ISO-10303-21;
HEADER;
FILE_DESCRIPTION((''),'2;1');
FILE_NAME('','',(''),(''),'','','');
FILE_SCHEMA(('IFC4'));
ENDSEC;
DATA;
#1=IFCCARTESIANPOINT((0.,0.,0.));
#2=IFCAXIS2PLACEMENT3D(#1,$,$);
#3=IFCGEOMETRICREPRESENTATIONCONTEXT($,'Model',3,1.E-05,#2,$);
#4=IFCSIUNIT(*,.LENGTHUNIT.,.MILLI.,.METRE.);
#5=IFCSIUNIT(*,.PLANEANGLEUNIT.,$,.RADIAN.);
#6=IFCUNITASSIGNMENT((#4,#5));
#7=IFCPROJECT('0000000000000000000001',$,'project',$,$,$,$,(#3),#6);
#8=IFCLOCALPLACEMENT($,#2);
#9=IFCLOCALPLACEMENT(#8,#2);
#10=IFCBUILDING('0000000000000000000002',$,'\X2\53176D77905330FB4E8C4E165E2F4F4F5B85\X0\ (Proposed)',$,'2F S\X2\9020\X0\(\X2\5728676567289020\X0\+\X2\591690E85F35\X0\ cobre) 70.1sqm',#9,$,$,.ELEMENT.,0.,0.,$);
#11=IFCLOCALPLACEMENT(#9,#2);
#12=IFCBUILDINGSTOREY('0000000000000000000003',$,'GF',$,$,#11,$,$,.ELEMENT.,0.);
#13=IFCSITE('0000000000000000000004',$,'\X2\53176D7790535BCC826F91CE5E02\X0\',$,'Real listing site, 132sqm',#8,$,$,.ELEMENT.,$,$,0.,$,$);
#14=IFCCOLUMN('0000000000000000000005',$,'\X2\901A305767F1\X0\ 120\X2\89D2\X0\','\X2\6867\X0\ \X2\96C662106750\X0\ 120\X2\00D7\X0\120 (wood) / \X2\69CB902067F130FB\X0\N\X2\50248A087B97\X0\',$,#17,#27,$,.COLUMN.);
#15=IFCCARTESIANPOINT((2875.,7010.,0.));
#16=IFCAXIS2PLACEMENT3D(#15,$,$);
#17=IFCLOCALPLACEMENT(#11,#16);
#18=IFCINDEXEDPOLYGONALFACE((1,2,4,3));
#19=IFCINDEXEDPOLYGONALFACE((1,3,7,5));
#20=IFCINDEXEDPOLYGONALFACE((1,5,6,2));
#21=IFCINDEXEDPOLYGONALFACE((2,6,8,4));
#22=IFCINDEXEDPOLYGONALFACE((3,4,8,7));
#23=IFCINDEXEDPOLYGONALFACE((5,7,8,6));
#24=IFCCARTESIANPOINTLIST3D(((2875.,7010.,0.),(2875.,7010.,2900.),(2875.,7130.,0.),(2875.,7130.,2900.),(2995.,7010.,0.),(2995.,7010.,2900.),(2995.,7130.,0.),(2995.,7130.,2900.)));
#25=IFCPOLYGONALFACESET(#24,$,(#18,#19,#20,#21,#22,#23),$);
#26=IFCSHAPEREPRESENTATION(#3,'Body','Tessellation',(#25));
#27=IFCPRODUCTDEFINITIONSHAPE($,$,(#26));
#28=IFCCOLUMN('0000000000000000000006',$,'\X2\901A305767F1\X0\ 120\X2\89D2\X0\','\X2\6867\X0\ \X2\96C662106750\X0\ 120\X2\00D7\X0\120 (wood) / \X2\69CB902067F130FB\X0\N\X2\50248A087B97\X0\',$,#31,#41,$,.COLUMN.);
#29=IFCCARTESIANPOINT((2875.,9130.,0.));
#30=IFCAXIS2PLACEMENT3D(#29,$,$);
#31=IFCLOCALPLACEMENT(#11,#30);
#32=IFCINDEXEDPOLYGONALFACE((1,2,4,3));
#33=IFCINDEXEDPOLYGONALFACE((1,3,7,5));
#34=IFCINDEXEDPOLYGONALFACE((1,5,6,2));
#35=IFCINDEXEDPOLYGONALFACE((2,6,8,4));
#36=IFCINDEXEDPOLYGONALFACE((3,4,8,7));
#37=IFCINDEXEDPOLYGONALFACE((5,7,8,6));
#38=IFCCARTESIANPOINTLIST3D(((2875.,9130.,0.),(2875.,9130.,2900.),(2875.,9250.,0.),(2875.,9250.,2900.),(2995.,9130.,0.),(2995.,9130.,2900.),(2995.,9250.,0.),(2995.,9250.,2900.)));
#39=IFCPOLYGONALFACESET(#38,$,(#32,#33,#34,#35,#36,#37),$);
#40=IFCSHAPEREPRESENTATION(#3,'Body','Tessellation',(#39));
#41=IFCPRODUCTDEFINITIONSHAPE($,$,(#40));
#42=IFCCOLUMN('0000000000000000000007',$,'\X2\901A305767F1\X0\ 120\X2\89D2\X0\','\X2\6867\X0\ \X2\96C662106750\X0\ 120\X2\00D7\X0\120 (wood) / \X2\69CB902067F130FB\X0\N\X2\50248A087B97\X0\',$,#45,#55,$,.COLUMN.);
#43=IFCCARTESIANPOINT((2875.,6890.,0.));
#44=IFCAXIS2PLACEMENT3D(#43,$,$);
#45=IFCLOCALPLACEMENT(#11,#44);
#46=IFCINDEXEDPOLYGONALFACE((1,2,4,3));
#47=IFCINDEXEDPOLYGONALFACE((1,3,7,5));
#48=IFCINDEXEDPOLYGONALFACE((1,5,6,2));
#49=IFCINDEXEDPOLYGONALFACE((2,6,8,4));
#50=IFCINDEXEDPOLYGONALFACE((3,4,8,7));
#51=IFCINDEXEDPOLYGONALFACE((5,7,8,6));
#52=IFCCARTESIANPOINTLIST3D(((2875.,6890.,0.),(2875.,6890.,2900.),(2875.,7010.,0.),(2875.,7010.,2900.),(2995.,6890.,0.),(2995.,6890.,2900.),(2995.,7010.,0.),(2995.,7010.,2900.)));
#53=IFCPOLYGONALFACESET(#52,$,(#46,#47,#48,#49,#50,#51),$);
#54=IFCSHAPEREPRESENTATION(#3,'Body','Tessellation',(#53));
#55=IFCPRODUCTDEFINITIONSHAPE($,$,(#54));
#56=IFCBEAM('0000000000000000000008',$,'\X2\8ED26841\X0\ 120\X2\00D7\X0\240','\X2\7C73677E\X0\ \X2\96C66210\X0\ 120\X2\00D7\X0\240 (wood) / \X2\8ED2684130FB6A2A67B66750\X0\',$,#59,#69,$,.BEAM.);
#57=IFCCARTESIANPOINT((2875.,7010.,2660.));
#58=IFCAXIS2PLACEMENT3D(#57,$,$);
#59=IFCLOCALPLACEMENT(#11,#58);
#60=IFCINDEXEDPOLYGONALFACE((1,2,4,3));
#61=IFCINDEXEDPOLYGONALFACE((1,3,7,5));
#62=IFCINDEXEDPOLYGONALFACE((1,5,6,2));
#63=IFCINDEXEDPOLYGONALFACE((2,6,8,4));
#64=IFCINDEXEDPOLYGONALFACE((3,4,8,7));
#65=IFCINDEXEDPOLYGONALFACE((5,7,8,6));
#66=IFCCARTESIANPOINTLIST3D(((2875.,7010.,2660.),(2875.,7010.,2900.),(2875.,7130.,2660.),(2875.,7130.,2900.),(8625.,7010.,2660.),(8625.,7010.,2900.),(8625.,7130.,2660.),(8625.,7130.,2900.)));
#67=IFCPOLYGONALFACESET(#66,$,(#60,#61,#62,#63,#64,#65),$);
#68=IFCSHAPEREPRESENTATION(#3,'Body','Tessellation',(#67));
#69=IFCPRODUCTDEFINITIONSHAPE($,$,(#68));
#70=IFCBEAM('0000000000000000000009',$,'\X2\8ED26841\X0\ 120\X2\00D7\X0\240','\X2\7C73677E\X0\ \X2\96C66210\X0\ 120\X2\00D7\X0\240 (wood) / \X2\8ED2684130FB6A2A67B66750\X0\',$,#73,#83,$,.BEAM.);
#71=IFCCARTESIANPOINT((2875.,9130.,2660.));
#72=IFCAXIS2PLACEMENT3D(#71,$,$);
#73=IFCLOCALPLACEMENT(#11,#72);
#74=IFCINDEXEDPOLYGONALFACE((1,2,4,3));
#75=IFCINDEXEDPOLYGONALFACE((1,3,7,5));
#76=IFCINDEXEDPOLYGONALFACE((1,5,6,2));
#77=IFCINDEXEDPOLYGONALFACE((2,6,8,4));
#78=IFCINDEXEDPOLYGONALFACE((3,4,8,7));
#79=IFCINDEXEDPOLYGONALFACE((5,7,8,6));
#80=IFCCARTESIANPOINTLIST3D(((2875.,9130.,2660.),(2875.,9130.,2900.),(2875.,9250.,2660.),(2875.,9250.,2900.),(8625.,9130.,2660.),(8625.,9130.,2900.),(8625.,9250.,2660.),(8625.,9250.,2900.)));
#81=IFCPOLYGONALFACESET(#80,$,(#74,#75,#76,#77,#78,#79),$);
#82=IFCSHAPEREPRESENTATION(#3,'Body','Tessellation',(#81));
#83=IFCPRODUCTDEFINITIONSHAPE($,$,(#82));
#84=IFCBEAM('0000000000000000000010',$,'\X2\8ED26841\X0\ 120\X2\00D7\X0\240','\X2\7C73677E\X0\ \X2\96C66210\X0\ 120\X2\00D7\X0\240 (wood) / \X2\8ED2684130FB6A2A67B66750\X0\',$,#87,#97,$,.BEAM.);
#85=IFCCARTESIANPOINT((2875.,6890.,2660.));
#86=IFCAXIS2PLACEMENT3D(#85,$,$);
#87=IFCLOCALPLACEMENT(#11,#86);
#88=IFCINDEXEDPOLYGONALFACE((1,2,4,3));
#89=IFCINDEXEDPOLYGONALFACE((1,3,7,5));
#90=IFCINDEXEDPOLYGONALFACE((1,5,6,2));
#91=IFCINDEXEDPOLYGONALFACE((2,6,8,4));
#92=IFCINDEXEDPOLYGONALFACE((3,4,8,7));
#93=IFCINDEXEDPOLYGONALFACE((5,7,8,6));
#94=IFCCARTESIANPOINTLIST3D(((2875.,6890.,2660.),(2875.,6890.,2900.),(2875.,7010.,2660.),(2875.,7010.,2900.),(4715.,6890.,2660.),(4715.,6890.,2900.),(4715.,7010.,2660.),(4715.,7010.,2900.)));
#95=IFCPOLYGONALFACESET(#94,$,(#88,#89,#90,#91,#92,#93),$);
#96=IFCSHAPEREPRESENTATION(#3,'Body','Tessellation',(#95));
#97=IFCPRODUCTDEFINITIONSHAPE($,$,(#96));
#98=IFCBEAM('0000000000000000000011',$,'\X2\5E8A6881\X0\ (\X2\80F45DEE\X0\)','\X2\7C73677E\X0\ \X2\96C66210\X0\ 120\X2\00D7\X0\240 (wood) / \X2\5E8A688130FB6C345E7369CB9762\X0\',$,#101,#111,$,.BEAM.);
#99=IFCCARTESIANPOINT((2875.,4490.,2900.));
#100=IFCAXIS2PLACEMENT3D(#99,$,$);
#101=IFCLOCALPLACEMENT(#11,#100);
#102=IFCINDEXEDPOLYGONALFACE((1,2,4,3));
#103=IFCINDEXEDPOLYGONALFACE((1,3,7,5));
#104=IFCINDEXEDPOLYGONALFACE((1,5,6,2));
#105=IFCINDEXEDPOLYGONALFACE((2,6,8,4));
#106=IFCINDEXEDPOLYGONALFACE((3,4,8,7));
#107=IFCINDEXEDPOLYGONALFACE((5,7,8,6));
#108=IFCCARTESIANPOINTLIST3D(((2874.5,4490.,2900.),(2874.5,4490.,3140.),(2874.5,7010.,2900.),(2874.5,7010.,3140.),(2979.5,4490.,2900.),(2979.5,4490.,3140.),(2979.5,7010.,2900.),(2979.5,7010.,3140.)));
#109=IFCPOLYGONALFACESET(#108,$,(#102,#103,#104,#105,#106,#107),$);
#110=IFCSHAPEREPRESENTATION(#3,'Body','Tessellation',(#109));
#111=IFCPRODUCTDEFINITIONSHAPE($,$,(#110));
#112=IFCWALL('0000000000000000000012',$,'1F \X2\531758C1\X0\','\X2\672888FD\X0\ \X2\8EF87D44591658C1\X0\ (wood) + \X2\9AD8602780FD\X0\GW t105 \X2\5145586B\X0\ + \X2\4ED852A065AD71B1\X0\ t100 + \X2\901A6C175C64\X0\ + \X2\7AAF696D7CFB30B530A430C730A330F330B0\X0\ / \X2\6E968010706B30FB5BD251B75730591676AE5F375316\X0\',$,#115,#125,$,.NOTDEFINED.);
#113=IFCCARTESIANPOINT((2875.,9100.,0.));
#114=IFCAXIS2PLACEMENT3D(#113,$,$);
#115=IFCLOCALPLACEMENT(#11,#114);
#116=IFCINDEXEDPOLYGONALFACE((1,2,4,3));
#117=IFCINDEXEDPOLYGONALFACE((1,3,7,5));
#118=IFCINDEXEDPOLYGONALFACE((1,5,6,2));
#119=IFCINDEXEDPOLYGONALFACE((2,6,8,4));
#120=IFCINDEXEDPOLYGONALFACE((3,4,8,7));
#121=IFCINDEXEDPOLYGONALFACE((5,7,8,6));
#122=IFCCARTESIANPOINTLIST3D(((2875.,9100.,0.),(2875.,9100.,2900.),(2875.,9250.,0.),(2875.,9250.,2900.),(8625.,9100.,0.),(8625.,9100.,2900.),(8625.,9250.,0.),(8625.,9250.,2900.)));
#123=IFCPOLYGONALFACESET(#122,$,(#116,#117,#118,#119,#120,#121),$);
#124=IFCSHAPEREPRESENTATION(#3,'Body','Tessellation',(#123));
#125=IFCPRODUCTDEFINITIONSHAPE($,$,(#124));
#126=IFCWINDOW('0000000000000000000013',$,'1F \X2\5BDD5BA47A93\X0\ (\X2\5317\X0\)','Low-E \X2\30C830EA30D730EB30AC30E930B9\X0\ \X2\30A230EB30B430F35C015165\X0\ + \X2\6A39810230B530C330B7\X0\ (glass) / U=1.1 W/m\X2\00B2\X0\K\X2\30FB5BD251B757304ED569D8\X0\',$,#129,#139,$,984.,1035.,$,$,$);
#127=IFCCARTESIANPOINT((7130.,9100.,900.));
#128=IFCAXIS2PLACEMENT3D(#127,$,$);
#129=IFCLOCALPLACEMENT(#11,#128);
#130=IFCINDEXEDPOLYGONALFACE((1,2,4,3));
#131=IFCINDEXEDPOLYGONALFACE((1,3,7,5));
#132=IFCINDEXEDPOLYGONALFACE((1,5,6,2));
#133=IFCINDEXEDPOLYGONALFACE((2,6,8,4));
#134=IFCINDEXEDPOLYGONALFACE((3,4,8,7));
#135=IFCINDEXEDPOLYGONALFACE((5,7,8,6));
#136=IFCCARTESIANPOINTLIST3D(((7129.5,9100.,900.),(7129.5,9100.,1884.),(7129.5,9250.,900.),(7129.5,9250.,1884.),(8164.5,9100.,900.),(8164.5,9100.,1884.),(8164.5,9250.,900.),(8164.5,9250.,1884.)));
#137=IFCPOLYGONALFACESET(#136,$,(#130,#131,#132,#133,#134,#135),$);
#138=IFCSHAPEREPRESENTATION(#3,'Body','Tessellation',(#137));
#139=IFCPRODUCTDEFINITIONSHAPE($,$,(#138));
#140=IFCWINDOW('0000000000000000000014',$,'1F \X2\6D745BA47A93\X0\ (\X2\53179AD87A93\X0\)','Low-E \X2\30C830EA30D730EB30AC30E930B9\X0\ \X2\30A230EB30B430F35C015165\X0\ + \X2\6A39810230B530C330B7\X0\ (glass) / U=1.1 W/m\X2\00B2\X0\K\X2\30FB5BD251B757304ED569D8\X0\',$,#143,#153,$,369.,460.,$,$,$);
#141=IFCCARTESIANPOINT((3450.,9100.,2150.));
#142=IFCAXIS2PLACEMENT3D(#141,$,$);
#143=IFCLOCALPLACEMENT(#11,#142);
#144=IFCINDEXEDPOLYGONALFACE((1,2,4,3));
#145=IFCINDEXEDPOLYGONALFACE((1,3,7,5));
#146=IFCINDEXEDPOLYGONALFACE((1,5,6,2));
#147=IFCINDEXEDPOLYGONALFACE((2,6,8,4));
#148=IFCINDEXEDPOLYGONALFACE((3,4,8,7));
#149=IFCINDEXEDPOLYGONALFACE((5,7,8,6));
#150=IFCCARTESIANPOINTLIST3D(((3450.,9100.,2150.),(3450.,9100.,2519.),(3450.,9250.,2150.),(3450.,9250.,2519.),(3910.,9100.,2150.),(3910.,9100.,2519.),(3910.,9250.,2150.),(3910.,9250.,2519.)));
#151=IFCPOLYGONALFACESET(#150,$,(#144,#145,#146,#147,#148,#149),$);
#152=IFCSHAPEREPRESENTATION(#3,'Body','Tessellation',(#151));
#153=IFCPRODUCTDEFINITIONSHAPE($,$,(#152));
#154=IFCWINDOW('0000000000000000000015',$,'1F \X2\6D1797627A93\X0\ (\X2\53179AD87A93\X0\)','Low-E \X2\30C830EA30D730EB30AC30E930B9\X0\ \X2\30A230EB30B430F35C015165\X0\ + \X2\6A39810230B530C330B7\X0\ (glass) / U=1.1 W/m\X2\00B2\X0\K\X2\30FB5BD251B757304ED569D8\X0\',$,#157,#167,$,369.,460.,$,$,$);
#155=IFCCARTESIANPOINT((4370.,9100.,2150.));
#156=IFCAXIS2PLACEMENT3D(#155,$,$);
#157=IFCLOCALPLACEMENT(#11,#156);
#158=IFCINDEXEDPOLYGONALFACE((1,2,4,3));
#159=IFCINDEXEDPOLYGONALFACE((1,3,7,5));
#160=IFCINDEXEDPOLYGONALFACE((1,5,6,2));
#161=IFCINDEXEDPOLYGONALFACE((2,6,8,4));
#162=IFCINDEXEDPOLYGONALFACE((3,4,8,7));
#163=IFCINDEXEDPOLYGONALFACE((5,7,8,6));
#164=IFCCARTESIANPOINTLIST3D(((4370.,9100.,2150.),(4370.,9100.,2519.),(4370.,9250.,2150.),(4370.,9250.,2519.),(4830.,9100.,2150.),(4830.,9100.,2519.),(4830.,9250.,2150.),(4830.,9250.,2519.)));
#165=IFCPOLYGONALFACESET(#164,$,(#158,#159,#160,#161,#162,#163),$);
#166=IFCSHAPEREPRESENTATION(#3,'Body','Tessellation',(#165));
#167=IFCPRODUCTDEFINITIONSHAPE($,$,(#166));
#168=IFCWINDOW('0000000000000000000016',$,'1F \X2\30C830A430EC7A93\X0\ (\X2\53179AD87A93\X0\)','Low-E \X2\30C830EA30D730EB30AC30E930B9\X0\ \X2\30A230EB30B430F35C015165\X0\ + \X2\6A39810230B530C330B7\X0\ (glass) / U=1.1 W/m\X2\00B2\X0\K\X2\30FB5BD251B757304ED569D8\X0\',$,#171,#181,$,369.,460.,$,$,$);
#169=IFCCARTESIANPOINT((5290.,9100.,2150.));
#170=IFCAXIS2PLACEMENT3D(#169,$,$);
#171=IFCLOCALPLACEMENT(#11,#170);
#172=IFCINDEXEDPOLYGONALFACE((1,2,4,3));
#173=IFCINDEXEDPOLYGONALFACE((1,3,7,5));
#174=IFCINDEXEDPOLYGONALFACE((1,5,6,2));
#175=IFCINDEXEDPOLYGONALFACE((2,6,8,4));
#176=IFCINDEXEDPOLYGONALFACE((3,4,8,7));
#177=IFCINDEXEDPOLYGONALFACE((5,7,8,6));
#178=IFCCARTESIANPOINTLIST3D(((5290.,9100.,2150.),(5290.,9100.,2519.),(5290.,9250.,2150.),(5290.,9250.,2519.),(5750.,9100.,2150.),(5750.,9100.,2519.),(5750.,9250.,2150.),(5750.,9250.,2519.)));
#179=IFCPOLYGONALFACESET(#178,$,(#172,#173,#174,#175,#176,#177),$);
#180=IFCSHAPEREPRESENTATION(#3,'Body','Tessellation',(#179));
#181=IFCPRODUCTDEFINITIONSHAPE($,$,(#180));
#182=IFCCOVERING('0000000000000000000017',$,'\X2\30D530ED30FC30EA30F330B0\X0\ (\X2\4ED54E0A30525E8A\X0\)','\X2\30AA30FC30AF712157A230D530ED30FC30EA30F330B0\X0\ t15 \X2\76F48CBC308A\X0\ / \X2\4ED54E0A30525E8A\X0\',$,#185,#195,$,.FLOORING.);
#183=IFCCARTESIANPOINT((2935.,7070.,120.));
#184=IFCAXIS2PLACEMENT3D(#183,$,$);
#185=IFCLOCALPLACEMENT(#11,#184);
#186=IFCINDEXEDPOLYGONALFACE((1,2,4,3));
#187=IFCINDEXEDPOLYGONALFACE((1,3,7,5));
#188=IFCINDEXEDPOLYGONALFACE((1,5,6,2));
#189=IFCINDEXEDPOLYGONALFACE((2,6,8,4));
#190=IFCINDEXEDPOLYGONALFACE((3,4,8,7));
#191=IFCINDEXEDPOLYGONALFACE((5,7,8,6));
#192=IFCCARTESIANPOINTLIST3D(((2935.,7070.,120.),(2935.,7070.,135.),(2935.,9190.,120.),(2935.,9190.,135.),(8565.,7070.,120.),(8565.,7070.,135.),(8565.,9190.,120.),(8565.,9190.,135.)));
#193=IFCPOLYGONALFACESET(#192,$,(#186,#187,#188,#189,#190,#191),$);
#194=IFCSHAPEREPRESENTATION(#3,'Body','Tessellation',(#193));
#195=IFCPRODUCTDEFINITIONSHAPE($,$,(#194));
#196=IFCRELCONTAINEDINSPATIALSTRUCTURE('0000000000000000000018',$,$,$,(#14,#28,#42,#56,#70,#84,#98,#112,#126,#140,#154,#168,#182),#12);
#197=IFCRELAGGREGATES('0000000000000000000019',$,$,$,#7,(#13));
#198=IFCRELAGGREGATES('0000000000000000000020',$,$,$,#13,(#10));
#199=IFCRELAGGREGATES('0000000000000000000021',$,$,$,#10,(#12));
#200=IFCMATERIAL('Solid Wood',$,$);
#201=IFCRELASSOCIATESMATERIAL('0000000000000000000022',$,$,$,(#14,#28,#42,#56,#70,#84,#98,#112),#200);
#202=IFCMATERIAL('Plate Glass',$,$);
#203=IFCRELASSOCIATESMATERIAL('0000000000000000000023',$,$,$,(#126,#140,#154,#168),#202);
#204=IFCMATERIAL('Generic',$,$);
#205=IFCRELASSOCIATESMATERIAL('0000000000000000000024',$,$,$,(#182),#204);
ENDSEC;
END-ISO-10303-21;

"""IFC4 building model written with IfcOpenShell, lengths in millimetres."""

from ifc_helpers import new_model, si_unit, frame, frame_2d, origin, place, context, project, spatial, rectangle, extrude, material, element, fill, save


model = new_model("IFC4")

# Units and contexts
model_context = context("Model", 3, precision=1e-05, world=origin())
ifc_project = project(units=[si_unit("LENGTHUNIT", "METRE", prefix="MILLI"), si_unit("PLANEANGLEUNIT", "RADIAN")], contexts=[model_context])

# Site, building, storey
site_placement = place(None, origin())
site = spatial("IfcSite", under=ifc_project, at=site_placement, Name="北海道富良野市", ObjectType="Real listing site, 132sqm", CompositionType="ELEMENT", RefElevation=0.0)
building_placement = place(site_placement, origin())
building = spatial("IfcBuilding", under=site, at=building_placement, Name="北海道・二世帯住宅 (Proposed)", ObjectType="2F S造(在来木造+外部張 cobre) 70.1sqm", CompositionType="ELEMENT", ElevationOfRefHeight=0.0, ElevationOfTerrain=0.0)
storey_placement = place(building_placement, origin())
storey = spatial("IfcBuildingStorey", under=building, at=storey_placement, Name="GF", CompositionType="ELEMENT", Elevation=0.0)

# Columns
ifc_material_1 = material(Name="Solid Wood")
column_1_placement = place(storey_placement, frame((2875.0, 7010.0, 0.0)))
element("IfcColumn", 1, at=column_1_placement, inside=storey, material=ifc_material_1, Name="通し柱 120角", Description="桧 集成材 120×120 (wood) / 構造柱・N値計算", PredefinedType="COLUMN", context=model_context, shape_type="SweptSolid", body=[
    extrude(rectangle(XDim=120.0, YDim=120.0, at=frame_2d((60.0, 60.0))), frame((2875.0, 7010.0, 0.0)), (0.0, 0.0, 1.0), 2900.0),
])
column_2_placement = place(storey_placement, frame((2875.0, 9130.0, 0.0)))
element("IfcColumn", 2, at=column_2_placement, inside=storey, material=ifc_material_1, Name="通し柱 120角", Description="桧 集成材 120×120 (wood) / 構造柱・N値計算", PredefinedType="COLUMN", context=model_context, shape_type="SweptSolid", body=[
    extrude(rectangle(XDim=120.0, YDim=120.0, at=frame_2d((60.0, 60.0))), frame((2875.0, 9130.0, 0.0)), (0.0, 0.0, 1.0), 2900.0),
])
column_3_placement = place(storey_placement, frame((2875.0, 6890.0, 0.0)))
element("IfcColumn", 3, at=column_3_placement, inside=storey, material=ifc_material_1, Name="通し柱 120角", Description="桧 集成材 120×120 (wood) / 構造柱・N値計算", PredefinedType="COLUMN", context=model_context, shape_type="SweptSolid", body=[
    extrude(rectangle(XDim=120.0, YDim=120.0, at=frame_2d((60.0, 60.0))), frame((2875.0, 6890.0, 0.0)), (0.0, 0.0, 1.0), 2900.0),
])

# Beams
beam_1_placement = place(storey_placement, frame((2875.0, 7010.0, 2660.0)))
element("IfcBeam", 4, at=beam_1_placement, inside=storey, material=ifc_material_1, Name="軒桁 120×240", Description="米松 集成 120×240 (wood) / 軒桁・横架材", PredefinedType="BEAM", context=model_context, shape_type="SweptSolid", body=[
    extrude(rectangle(XDim=5750.0, YDim=120.0, at=frame_2d((2875.0, 60.0))), frame((2875.0, 7010.0, 2660.0)), (0.0, 0.0, 1.0), 240.0),
])
beam_2_placement = place(storey_placement, frame((2875.0, 9130.0, 2660.0)))
element("IfcBeam", 5, at=beam_2_placement, inside=storey, material=ifc_material_1, Name="軒桁 120×240", Description="米松 集成 120×240 (wood) / 軒桁・横架材", PredefinedType="BEAM", context=model_context, shape_type="SweptSolid", body=[
    extrude(rectangle(XDim=5750.0, YDim=120.0, at=frame_2d((2875.0, 60.0))), frame((2875.0, 9130.0, 2660.0)), (0.0, 0.0, 1.0), 240.0),
])
beam_3_placement = place(storey_placement, frame((2875.0, 6890.0, 2660.0)))
element("IfcBeam", 6, at=beam_3_placement, inside=storey, material=ifc_material_1, Name="軒桁 120×240", Description="米松 集成 120×240 (wood) / 軒桁・横架材", PredefinedType="BEAM", context=model_context, shape_type="SweptSolid", body=[
    extrude(rectangle(XDim=1840.0, YDim=120.0, at=frame_2d((920.0, 60.0))), frame((2875.0, 6890.0, 2660.0)), (0.0, 0.0, 1.0), 240.0),
])
beam_4_placement = place(storey_placement, frame((2875.0, 4490.0, 2900.0)))
element("IfcBeam", 7, at=beam_4_placement, inside=storey, material=ifc_material_1, Name="床梁 (胴差)", Description="米松 集成 120×240 (wood) / 床梁・水平構面", PredefinedType="BEAM", context=model_context, shape_type="SweptSolid", body=[
    extrude(rectangle(XDim=105.0, YDim=2520.0, at=frame_2d((52.0, 1260.0))), frame((2875.0, 4490.0, 2900.0)), (0.0, 0.0, 1.0), 240.0),
])

# Wall, openings, windows
wall_1_placement = place(storey_placement, frame((2875.0, 9100.0, 0.0)))
wall_1 = element("IfcWall", 8, at=wall_1_placement, inside=storey, material=ifc_material_1, Name="1F 北壁", Description="木製 軸組外壁 (wood) + 高性能GW t105 充填 + 付加断熱 t100 + 通気層 + 窯業系サイディング / 準耐火・寒冷地外皮強化", PredefinedType="NOTDEFINED", context=model_context, shape_type="SweptSolid", body=[
    extrude(rectangle(XDim=5750.0, YDim=150.0, at=frame_2d((2875.0, 75.0))), frame((2875.0, 9100.0, 0.0)), (0.0, 0.0, 1.0), 2900.0),
])
opening_1_placement = place(storey_placement, frame((7130.0, 9100.0, 900.0)))
opening_1 = element("IfcOpeningElement", 9, at=opening_1_placement, cuts=wall_1, PredefinedType="NOTDEFINED", context=model_context, shape_type="SweptSolid", body=[
    extrude(rectangle(XDim=1035.0, YDim=150.0, at=frame_2d((517.0, 75.0))), frame((7130.0, 9100.0, 900.0)), (0.0, 0.0, 1.0), 984.0),
])
opening_2_placement = place(storey_placement, frame((3450.0, 9100.0, 2150.0)))
opening_2 = element("IfcOpeningElement", 10, at=opening_2_placement, cuts=wall_1, PredefinedType="NOTDEFINED", context=model_context, shape_type="SweptSolid", body=[
    extrude(rectangle(XDim=460.0, YDim=150.0, at=frame_2d((230.0, 75.0))), frame((3450.0, 9100.0, 2150.0)), (0.0, 0.0, 1.0), 369.0),
])
opening_3_placement = place(storey_placement, frame((4370.0, 9100.0, 2150.0)))
opening_3 = element("IfcOpeningElement", 11, at=opening_3_placement, cuts=wall_1, PredefinedType="NOTDEFINED", context=model_context, shape_type="SweptSolid", body=[
    extrude(rectangle(XDim=460.0, YDim=150.0, at=frame_2d((230.0, 75.0))), frame((4370.0, 9100.0, 2150.0)), (0.0, 0.0, 1.0), 369.0),
])
opening_4_placement = place(storey_placement, frame((5290.0, 9100.0, 2150.0)))
opening_4 = element("IfcOpeningElement", 12, at=opening_4_placement, cuts=wall_1, PredefinedType="NOTDEFINED", context=model_context, shape_type="SweptSolid", body=[
    extrude(rectangle(XDim=460.0, YDim=150.0, at=frame_2d((230.0, 75.0))), frame((5290.0, 9100.0, 2150.0)), (0.0, 0.0, 1.0), 369.0),
])
ifc_material_2 = material(Name="Plate Glass")
window_1_placement = place(storey_placement, frame((7130.0, 9100.0, 900.0)))
window_1 = element("IfcWindow", 13, at=window_1_placement, inside=storey, material=ifc_material_2, Name="1F 寝室窓 (北)", Description="Low-E トリプルガラス アルゴン封入 + 樹脂サッシ (glass) / U=1.1 W/m²K・寒冷地仕様", OverallHeight=984.0, OverallWidth=1035.0, context=model_context, shape_type="SweptSolid", body=[
    extrude(rectangle(XDim=1035.0, YDim=150.0, at=frame_2d((517.0, 75.0))), frame((7130.0, 9100.0, 900.0)), (0.0, 0.0, 1.0), 984.0),
])
fill(opening_1, window_1)
window_2_placement = place(storey_placement, frame((3450.0, 9100.0, 2150.0)))
window_2 = element("IfcWindow", 14, at=window_2_placement, inside=storey, material=ifc_material_2, Name="1F 浴室窓 (北高窓)", Description="Low-E トリプルガラス アルゴン封入 + 樹脂サッシ (glass) / U=1.1 W/m²K・寒冷地仕様", OverallHeight=369.0, OverallWidth=460.0, context=model_context, shape_type="SweptSolid", body=[
    extrude(rectangle(XDim=460.0, YDim=150.0, at=frame_2d((230.0, 75.0))), frame((3450.0, 9100.0, 2150.0)), (0.0, 0.0, 1.0), 369.0),
])
fill(opening_2, window_2)
window_3_placement = place(storey_placement, frame((4370.0, 9100.0, 2150.0)))
window_3 = element("IfcWindow", 15, at=window_3_placement, inside=storey, material=ifc_material_2, Name="1F 洗面窓 (北高窓)", Description="Low-E トリプルガラス アルゴン封入 + 樹脂サッシ (glass) / U=1.1 W/m²K・寒冷地仕様", OverallHeight=369.0, OverallWidth=460.0, context=model_context, shape_type="SweptSolid", body=[
    extrude(rectangle(XDim=460.0, YDim=150.0, at=frame_2d((230.0, 75.0))), frame((4370.0, 9100.0, 2150.0)), (0.0, 0.0, 1.0), 369.0),
])
fill(opening_3, window_3)
window_4_placement = place(storey_placement, frame((5290.0, 9100.0, 2150.0)))
window_4 = element("IfcWindow", 16, at=window_4_placement, inside=storey, material=ifc_material_2, Name="1F トイレ窓 (北高窓)", Description="Low-E トリプルガラス アルゴン封入 + 樹脂サッシ (glass) / U=1.1 W/m²K・寒冷地仕様", OverallHeight=369.0, OverallWidth=460.0, context=model_context, shape_type="SweptSolid", body=[
    extrude(rectangle(XDim=460.0, YDim=150.0, at=frame_2d((230.0, 75.0))), frame((5290.0, 9100.0, 2150.0)), (0.0, 0.0, 1.0), 369.0),
])
fill(opening_4, window_4)

# Covering
ifc_material_3 = material(Name="Generic")
covering_1_placement = place(storey_placement, frame((2935.0, 7070.0, 120.0)))
element("IfcCovering", 17, at=covering_1_placement, inside=storey, material=ifc_material_3, Name="フローリング (仕上げ床)", Description="オーク無垢フローリング t15 直貼り / 仕上げ床", PredefinedType="FLOORING", context=model_context, shape_type="SweptSolid", body=[
    extrude(rectangle(XDim=5630.0, YDim=2120.0, at=frame_2d((2815.0, 1060.0))), frame((2935.0, 7070.0, 120.0)), (0.0, 0.0, 1.0), 15.0),
])

save(model, "model.ifc")
